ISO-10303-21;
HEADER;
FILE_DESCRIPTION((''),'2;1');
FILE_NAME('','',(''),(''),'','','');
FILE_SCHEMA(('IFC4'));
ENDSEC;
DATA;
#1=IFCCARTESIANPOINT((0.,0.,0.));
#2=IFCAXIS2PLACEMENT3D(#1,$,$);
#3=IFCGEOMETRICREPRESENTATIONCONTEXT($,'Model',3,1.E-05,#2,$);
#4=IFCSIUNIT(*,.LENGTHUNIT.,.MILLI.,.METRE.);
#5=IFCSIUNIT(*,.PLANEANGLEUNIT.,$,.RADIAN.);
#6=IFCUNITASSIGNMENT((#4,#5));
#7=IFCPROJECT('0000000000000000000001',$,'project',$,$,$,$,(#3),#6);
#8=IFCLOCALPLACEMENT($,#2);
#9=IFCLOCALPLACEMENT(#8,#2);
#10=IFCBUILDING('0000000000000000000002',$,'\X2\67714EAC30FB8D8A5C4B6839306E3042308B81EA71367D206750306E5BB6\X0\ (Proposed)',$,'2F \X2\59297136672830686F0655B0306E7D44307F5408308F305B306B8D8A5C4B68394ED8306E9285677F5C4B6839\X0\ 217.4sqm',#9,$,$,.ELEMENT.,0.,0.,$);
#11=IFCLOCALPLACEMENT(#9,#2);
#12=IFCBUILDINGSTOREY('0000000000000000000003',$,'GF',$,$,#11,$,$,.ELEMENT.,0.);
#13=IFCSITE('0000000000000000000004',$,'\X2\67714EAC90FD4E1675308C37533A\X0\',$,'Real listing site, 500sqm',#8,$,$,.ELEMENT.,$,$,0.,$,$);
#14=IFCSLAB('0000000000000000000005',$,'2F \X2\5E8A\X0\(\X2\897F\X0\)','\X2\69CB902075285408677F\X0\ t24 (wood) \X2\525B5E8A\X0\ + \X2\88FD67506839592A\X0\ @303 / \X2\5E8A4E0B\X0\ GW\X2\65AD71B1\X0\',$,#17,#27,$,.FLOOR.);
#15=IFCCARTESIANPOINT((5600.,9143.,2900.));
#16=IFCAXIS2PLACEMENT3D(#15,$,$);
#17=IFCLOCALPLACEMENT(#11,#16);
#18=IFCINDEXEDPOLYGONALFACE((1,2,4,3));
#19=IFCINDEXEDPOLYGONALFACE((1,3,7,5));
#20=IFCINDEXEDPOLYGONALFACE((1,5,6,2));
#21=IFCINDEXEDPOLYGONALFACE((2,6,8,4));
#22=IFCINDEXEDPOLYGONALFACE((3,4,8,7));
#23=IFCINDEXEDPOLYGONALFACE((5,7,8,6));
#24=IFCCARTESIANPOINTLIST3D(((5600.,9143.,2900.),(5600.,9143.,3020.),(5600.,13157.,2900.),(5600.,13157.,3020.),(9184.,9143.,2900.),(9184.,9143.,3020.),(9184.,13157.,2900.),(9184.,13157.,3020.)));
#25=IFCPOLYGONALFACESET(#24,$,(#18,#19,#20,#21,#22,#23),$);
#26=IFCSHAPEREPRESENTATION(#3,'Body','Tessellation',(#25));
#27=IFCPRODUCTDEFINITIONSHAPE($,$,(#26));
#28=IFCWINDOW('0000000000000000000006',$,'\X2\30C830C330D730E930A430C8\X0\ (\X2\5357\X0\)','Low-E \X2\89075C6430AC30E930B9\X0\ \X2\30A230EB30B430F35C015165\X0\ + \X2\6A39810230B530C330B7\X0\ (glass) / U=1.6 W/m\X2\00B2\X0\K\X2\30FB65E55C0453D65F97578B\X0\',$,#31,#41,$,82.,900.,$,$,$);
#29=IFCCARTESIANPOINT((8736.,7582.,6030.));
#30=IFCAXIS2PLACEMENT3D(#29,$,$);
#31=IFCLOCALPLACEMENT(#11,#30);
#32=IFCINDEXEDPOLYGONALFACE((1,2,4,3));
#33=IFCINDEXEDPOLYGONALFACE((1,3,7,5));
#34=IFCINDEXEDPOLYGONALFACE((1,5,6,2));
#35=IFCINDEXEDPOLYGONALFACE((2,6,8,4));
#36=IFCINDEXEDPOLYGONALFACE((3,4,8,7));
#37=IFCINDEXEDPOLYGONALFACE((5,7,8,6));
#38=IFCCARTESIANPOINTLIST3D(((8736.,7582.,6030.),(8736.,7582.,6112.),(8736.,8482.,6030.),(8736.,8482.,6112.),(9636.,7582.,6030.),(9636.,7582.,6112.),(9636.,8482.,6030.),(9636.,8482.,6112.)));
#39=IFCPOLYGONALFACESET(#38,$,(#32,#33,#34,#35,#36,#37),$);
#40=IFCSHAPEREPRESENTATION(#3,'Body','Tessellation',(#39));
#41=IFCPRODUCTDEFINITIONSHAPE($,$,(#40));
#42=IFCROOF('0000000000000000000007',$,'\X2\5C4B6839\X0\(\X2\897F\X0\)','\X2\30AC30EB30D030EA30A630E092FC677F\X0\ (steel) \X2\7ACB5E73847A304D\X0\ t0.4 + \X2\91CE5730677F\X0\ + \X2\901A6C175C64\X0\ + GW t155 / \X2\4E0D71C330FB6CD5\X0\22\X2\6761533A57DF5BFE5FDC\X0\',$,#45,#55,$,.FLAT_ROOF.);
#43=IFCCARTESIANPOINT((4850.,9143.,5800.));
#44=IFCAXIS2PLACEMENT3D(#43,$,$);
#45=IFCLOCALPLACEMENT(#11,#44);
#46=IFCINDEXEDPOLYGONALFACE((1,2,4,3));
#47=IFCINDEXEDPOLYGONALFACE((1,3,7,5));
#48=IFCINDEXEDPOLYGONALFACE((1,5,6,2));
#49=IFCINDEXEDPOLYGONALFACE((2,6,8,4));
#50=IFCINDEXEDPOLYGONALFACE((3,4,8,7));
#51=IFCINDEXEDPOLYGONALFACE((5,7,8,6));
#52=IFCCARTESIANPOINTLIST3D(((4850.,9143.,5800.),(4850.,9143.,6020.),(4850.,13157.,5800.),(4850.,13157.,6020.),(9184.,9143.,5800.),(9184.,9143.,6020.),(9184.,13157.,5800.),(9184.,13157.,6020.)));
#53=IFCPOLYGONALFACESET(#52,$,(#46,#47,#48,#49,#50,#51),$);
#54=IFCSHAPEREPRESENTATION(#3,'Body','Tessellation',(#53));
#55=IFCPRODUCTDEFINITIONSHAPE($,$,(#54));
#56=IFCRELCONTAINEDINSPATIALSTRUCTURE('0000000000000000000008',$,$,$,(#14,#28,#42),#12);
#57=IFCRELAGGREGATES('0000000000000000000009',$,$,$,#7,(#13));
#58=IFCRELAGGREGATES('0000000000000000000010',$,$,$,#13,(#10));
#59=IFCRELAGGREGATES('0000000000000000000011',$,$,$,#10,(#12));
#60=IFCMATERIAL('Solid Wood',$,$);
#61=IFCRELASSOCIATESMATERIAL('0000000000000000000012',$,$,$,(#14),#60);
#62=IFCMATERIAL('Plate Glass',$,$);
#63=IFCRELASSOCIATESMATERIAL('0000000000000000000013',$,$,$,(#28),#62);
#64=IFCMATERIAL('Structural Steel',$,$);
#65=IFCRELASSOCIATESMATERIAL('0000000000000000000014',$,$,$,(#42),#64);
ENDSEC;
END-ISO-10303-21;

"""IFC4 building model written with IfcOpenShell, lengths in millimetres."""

from ifc_helpers import new_model, si_unit, frame, frame_2d, origin, place, context, project, spatial, rectangle, extrude, material, element, save


model = new_model("IFC4")

# Units and contexts
model_context = context("Model", 3, precision=1e-05, world=origin())
ifc_project = project(units=[si_unit("LENGTHUNIT", "METRE", prefix="MILLI"), si_unit("PLANEANGLEUNIT", "RADIAN")], contexts=[model_context])

# Site, building, storey
site_placement = place(None, origin())
site = spatial("IfcSite", under=ifc_project, at=site_placement, Name="東京都世田谷区", ObjectType="Real listing site, 500sqm", CompositionType="ELEMENT", RefElevation=0.0)
building_placement = place(site_placement, origin())
building = spatial("IfcBuilding", under=site, at=building_placement, Name="東京・越屋根のある自然素材の家 (Proposed)", ObjectType="2F 天然木と漆喰の組み合わせに越屋根付の銅板屋根 217.4sqm", CompositionType="ELEMENT", ElevationOfRefHeight=0.0, ElevationOfTerrain=0.0)
storey_placement = place(building_placement, origin())
storey = spatial("IfcBuildingStorey", under=building, at=storey_placement, Name="GF", CompositionType="ELEMENT", Elevation=0.0)

# Shared definitions
ifc_material_1 = material(Name="Solid Wood")

# Slab
slab_1_placement = place(storey_placement, frame((5600.0, 9143.0, 2900.0)))
element("IfcSlab", 1, at=slab_1_placement, inside=storey, material=ifc_material_1, Name="2F 床(西)", Description="構造用合板 t24 (wood) 剛床 + 製材根太 @303 / 床下 GW断熱", PredefinedType="FLOOR", context=model_context, shape_type="SweptSolid", body=[
    extrude(rectangle(XDim=3584.0, YDim=4014.0, at=frame_2d((1792.0, 2007.0))), frame((5600.0, 9143.0, 2900.0)), (0.0, 0.0, 1.0), 120.0),
])

# Window
ifc_material_2 = material(Name="Plate Glass")
window_placement = place(storey_placement, frame((8736.0, 7582.0, 6030.0)))
element("IfcWindow", 2, at=window_placement, inside=storey, material=ifc_material_2, Name="トップライト (南)", Description="Low-E 複層ガラス アルゴン封入 + 樹脂サッシ (glass) / U=1.6 W/m²K・日射取得型", OverallHeight=82.0, OverallWidth=900.0, context=model_context, shape_type="SweptSolid", body=[
    extrude(rectangle(XDim=900.0, YDim=900.0, at=frame_2d((450.0, 450.0))), frame((8736.0, 7582.0, 6030.0)), (0.0, 0.0, 1.0), 82.0),
])

# Roof
ifc_material_3 = material(Name="Structural Steel")
for number, where, name in (
    (3, (4850.0, 9143.0, 5800.0), "屋根(西)"),
):
    element("IfcRoof", number, at=place(storey_placement, frame(where)), inside=storey, material=ifc_material_3, Name=name, Description="ガルバリウム鋼板 (steel) 立平葺き t0.4 + 野地板 + 通気層 + GW t155 / 不燃・法22条区域対応", PredefinedType="FLAT_ROOF", context=model_context, shape_type="SweptSolid", body=[
        extrude(rectangle(XDim=4334.0, YDim=4014.0, at=frame_2d((2167.0, 2007.0))), frame((4850.0, 9143.0, 5800.0)), (0.0, 0.0, 1.0), 220.0),
    ])

save(model, "model.ifc")
